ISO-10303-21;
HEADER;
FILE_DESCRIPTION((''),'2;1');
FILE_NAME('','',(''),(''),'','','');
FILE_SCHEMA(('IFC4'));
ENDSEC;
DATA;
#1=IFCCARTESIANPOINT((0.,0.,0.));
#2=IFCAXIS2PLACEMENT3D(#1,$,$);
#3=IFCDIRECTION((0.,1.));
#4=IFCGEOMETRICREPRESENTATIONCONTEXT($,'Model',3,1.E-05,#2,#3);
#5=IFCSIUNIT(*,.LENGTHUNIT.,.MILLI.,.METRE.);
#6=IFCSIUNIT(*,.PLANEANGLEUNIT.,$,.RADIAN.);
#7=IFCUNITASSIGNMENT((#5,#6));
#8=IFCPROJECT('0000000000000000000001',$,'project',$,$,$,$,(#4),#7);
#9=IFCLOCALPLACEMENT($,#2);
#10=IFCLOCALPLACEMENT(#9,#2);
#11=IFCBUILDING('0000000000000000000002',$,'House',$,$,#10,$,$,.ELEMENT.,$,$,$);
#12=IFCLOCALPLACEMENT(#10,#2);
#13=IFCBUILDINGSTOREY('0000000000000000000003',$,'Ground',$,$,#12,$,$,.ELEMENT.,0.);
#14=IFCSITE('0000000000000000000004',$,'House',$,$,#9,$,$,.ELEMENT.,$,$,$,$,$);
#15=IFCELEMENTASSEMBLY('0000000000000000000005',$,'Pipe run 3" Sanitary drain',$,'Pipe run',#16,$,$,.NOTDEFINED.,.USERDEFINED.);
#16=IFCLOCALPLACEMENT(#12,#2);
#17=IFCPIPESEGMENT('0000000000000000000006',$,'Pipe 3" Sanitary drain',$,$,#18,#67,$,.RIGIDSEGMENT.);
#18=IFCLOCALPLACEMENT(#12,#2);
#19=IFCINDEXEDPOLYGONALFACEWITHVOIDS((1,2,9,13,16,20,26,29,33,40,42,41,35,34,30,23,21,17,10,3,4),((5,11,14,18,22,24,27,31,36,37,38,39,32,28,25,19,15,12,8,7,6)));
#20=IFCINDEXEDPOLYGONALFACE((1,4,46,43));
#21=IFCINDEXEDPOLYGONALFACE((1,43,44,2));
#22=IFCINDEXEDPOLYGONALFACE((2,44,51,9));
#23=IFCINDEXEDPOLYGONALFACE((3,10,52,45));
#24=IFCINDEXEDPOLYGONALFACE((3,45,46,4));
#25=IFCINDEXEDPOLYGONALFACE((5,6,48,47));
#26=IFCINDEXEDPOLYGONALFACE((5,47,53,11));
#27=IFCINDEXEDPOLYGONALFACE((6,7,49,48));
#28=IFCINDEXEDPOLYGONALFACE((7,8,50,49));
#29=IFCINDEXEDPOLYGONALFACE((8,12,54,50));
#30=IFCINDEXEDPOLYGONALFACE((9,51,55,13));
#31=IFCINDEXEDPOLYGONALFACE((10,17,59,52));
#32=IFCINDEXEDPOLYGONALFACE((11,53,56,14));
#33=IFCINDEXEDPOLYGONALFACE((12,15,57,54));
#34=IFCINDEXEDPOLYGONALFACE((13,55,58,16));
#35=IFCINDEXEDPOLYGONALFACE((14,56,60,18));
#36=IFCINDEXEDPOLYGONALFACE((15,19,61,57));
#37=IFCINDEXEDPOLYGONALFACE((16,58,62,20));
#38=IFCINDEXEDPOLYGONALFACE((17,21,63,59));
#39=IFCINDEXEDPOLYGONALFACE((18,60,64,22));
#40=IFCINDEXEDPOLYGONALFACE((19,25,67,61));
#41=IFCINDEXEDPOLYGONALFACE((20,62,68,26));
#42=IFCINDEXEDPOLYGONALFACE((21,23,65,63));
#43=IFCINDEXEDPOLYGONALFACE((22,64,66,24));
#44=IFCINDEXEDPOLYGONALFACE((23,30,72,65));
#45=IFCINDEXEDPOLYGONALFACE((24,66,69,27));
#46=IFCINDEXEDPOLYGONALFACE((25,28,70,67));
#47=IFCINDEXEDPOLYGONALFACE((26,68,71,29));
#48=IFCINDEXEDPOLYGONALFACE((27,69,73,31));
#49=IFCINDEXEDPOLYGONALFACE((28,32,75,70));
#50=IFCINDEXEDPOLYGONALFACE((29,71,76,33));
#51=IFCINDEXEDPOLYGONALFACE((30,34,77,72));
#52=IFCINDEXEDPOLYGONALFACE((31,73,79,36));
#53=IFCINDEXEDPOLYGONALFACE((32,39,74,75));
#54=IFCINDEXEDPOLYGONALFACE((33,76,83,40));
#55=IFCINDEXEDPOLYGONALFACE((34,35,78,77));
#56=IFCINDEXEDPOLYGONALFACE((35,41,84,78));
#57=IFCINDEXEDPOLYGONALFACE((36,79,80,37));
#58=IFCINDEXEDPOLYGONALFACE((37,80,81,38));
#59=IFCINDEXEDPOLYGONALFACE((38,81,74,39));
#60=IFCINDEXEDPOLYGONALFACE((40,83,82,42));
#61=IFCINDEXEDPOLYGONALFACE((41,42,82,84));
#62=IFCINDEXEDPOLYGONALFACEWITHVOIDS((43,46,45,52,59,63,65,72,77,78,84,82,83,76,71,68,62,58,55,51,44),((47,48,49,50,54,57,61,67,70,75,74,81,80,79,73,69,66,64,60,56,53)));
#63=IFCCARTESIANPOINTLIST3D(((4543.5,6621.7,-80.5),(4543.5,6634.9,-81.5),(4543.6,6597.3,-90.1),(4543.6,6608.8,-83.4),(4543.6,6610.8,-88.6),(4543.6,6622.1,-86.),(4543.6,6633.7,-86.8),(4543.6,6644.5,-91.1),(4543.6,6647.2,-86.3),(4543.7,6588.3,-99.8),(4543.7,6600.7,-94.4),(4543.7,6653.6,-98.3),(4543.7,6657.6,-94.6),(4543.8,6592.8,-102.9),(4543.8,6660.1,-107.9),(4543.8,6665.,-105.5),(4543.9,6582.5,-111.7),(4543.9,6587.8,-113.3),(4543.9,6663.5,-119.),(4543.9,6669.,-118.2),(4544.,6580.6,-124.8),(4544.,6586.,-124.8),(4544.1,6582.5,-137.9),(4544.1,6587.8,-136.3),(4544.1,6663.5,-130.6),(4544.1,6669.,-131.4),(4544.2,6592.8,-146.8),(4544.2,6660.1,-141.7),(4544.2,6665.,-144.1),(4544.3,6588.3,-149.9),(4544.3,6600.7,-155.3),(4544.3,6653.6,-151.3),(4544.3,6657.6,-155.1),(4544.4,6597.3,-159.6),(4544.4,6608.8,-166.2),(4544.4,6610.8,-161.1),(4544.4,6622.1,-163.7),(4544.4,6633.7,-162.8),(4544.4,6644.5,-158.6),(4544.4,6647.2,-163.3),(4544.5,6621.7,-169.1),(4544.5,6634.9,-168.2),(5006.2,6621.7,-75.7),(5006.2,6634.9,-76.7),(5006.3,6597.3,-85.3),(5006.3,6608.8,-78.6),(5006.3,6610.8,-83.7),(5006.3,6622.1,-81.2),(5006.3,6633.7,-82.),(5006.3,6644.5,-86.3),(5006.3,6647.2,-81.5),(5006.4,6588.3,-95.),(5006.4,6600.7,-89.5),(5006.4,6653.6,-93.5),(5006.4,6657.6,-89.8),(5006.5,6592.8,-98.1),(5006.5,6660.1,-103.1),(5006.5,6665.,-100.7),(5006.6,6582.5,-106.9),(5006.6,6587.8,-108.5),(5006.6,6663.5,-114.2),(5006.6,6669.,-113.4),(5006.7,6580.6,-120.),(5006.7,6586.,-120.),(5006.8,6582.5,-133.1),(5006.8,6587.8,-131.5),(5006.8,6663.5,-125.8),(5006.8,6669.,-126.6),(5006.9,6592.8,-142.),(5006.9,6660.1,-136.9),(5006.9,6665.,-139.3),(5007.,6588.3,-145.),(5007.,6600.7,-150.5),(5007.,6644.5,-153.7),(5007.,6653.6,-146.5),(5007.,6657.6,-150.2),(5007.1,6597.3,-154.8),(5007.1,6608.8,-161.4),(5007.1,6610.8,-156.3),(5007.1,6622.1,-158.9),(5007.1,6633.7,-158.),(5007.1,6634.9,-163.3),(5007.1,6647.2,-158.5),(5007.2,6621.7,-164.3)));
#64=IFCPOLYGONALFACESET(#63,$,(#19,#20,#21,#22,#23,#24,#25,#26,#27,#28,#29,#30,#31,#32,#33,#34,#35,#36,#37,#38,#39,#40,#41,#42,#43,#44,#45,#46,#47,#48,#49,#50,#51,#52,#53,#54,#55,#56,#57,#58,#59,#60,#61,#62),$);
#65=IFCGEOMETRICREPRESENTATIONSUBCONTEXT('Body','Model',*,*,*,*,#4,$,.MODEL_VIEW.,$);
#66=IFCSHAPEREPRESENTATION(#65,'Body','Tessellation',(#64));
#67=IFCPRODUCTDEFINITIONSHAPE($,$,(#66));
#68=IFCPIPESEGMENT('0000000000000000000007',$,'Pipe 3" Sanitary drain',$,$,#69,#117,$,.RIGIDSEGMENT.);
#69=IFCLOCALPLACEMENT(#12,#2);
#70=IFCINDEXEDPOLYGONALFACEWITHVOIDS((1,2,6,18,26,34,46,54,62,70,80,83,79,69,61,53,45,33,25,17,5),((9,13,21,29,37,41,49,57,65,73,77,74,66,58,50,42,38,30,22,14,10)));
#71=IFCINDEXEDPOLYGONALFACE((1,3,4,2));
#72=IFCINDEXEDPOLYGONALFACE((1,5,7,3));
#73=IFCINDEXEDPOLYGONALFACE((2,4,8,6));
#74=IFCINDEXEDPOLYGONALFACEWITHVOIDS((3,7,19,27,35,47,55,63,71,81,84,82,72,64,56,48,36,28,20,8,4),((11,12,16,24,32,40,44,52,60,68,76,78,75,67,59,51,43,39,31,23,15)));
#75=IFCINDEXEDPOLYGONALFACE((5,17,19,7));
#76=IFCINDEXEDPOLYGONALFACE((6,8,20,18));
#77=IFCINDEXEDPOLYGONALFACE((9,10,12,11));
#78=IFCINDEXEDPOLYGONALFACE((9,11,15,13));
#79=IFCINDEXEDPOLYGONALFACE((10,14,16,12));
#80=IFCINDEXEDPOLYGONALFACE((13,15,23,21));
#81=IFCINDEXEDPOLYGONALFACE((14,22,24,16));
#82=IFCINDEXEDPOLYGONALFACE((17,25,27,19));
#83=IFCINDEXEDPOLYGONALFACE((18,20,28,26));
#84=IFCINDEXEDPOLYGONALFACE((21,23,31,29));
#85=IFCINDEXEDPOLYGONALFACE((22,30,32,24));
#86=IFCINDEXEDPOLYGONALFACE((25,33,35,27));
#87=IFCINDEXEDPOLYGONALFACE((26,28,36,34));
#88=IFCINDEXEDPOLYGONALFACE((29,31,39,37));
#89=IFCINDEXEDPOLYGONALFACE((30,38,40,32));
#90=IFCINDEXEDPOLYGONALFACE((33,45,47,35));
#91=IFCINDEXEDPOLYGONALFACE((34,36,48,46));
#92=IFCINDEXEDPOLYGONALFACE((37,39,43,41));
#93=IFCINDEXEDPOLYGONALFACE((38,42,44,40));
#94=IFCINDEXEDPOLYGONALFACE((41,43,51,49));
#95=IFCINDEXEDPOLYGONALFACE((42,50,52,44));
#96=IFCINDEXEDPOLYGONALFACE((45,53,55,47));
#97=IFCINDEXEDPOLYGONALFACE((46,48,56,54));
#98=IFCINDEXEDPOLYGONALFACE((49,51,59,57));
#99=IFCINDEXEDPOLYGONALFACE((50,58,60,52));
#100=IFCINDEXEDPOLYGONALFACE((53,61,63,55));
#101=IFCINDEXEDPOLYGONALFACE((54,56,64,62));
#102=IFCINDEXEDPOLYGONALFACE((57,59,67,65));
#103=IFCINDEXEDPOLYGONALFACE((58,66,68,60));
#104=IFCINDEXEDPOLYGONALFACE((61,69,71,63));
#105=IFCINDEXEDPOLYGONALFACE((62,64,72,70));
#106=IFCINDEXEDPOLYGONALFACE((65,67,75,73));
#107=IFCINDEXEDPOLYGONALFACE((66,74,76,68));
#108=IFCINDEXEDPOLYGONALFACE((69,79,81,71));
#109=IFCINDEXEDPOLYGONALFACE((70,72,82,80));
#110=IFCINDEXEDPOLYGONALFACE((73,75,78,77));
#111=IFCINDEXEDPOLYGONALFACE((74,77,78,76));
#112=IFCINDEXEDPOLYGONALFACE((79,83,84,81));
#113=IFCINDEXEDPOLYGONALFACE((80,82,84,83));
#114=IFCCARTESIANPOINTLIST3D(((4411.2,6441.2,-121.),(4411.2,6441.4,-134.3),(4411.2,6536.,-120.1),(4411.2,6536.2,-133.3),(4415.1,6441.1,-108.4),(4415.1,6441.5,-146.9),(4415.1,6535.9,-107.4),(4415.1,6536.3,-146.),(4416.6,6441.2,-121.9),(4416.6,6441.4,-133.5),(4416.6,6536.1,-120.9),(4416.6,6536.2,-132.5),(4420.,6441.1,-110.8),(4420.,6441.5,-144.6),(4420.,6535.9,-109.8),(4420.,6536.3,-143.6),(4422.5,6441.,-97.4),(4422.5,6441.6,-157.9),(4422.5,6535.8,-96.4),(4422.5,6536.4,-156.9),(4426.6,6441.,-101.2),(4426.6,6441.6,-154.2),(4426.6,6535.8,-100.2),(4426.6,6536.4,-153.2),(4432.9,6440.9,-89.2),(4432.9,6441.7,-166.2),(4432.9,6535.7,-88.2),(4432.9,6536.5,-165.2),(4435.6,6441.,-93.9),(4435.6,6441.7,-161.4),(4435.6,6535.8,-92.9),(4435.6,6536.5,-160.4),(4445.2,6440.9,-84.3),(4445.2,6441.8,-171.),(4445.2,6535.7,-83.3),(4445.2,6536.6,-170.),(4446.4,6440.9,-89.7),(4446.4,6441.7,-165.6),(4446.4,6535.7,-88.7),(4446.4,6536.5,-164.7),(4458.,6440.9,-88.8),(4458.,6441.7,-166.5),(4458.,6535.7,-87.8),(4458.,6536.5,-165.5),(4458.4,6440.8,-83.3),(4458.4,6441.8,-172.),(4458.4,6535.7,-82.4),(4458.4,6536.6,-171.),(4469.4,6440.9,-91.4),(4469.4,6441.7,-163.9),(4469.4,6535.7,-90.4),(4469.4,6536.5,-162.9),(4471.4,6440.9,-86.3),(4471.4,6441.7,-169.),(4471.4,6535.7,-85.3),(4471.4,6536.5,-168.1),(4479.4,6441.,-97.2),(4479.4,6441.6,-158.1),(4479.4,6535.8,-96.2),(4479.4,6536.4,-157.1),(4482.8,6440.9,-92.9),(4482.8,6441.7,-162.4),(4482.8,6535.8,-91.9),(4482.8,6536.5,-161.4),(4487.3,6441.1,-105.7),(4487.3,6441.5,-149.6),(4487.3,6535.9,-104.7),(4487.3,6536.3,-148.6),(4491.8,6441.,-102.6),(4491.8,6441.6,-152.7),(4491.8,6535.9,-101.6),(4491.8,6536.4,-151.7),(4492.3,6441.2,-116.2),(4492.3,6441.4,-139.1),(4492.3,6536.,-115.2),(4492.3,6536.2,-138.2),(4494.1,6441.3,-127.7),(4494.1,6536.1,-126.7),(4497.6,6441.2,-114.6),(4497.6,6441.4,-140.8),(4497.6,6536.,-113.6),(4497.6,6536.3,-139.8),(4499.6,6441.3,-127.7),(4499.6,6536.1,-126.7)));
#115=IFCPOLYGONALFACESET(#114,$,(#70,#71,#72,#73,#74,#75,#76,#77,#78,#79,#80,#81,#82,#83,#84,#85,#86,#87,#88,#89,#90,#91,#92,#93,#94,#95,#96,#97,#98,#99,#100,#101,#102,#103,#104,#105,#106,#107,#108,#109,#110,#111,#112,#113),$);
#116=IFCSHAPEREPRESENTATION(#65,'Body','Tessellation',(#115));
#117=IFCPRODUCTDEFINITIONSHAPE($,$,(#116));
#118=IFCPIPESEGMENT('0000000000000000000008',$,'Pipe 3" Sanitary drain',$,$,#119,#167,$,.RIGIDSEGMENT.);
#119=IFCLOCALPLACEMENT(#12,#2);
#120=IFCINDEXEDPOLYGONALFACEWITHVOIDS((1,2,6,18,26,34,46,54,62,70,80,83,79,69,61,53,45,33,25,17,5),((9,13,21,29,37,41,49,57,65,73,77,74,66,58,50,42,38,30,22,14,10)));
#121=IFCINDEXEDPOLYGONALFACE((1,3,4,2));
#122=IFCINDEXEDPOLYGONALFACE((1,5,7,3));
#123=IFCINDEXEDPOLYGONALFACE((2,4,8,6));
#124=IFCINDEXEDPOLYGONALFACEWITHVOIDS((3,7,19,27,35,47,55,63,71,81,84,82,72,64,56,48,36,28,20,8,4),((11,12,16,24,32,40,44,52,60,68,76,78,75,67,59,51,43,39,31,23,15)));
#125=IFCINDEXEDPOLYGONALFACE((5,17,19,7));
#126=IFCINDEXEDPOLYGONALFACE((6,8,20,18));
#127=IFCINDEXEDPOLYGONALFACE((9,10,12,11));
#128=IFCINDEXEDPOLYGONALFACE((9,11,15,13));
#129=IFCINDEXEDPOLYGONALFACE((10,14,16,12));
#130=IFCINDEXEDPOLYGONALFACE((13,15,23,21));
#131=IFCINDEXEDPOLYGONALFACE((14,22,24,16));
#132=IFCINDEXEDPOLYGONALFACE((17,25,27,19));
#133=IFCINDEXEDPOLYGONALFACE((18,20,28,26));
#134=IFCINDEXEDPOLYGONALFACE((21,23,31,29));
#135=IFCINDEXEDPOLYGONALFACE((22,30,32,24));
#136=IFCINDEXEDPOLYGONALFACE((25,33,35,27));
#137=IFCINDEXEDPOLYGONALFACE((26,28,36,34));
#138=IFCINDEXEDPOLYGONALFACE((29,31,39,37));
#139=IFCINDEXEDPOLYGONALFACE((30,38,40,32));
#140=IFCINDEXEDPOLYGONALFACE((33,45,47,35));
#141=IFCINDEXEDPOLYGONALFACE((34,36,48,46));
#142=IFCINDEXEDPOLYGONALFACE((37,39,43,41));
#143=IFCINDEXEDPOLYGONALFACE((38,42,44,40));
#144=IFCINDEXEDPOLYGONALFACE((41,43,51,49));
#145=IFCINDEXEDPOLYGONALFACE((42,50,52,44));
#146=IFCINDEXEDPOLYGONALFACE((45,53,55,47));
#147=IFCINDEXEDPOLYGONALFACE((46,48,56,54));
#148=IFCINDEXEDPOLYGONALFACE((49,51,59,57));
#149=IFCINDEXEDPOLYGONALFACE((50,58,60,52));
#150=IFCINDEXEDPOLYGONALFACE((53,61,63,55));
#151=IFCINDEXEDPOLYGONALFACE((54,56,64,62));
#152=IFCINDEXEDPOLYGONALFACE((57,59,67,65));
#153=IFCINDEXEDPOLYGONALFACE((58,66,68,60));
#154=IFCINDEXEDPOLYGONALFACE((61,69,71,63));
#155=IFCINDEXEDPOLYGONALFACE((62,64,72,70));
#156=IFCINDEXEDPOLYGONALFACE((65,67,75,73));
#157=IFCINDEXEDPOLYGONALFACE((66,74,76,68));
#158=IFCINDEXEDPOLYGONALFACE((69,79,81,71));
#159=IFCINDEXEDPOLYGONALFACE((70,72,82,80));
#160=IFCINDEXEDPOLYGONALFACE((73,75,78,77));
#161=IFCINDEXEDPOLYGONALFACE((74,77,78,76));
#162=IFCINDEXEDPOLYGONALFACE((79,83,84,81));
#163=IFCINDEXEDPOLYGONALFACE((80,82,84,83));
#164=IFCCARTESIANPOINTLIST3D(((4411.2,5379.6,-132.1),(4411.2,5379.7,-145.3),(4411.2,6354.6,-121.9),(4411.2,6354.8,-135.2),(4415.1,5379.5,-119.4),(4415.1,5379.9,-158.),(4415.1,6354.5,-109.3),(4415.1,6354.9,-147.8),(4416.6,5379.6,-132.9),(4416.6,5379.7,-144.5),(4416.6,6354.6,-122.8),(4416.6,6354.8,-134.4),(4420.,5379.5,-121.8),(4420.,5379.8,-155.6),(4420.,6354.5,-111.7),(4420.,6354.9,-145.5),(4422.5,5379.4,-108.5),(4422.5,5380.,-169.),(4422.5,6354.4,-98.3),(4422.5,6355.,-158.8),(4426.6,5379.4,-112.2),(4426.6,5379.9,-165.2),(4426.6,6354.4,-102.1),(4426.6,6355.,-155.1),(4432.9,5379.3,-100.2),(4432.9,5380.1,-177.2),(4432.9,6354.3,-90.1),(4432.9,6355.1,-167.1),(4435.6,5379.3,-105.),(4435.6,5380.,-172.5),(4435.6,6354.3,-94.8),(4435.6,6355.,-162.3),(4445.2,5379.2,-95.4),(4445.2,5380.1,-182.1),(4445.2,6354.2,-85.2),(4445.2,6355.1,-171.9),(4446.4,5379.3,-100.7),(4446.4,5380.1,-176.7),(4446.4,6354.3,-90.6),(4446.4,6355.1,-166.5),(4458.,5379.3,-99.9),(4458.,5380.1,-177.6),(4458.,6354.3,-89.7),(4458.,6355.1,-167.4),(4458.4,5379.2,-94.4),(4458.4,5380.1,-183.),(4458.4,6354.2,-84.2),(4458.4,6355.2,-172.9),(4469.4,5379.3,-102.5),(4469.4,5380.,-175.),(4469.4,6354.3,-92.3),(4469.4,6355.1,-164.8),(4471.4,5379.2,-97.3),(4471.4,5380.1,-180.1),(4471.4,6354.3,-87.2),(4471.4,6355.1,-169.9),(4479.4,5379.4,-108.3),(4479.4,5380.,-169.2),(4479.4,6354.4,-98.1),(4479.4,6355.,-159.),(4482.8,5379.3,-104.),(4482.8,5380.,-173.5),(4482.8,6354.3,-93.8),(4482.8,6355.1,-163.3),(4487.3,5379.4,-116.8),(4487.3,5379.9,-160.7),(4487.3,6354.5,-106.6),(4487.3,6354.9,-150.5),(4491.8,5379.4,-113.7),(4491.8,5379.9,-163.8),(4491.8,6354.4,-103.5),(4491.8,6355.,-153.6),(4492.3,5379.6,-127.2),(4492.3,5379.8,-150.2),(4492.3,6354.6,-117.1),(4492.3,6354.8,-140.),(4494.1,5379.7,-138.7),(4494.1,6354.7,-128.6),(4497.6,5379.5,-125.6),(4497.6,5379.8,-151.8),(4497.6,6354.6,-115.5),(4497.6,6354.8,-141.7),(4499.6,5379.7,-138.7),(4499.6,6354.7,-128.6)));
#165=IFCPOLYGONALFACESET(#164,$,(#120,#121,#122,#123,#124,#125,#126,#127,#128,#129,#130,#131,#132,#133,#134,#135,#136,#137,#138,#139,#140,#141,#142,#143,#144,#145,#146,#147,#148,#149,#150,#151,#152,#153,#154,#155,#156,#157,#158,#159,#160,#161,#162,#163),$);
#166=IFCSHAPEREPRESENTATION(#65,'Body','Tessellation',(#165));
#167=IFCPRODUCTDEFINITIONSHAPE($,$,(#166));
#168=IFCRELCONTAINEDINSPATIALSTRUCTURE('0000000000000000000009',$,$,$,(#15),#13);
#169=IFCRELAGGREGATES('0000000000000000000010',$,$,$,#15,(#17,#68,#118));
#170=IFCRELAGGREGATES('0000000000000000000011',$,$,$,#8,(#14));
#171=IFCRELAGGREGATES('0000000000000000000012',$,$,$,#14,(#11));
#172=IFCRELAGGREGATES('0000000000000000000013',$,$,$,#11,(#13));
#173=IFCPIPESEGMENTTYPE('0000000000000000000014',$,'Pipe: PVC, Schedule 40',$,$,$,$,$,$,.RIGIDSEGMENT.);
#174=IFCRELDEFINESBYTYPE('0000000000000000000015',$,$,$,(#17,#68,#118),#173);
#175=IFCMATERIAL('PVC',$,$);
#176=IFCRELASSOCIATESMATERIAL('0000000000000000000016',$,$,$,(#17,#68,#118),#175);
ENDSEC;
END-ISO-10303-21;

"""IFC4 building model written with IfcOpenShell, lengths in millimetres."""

from ifc_helpers import new_model, si_unit, direction, frame, origin, origin_with_axes, origin_2d, place, context, subcontext, project, spatial, hollow_circle, extrude, material, type_object, element, aggregate, save


model = new_model("IFC4")

# Units and contexts
model_context = context("Model", 3, precision=1e-05, world=origin(), true_north=direction((0.0, 1.0)))
body_context = subcontext(model_context, "Body", "Model", "MODEL_VIEW")
ifc_project = project(units=[si_unit("LENGTHUNIT", "METRE", prefix="MILLI"), si_unit("PLANEANGLEUNIT", "RADIAN")], contexts=[model_context])

# Site, building, storey
site_placement = place(None, origin())
site = spatial("IfcSite", under=ifc_project, at=site_placement, Name="House", CompositionType="ELEMENT")
building_placement = place(site_placement, origin())
building = spatial("IfcBuilding", under=site, at=building_placement, Name="House", CompositionType="ELEMENT")
storey_placement = place(building_placement, origin())
storey = spatial("IfcBuildingStorey", under=building, at=storey_placement, Name="Ground", CompositionType="ELEMENT", Elevation=0.0)

# Element assembly, pipe segments
ifc_material = material(Name="PVC")
pipe_segment_type = type_object("IfcPipeSegmentType", Name="Pipe: PVC, Schedule 40", PredefinedType="RIGIDSEGMENT")
assembly_1_placement = place(storey_placement, origin_with_axes())
assembly_1 = element("IfcElementAssembly", 1, at=assembly_1_placement, inside=storey, Name="Pipe run 3\" Sanitary drain", ObjectType="Pipe run", AssemblyPlace="NOTDEFINED", PredefinedType="USERDEFINED")
pipe_segment_1_placement = place(storey_placement, origin_with_axes())
pipe_segment_1 = element("IfcPipeSegment", 2, at=pipe_segment_1_placement, type_object=pipe_segment_type, material=ifc_material, Name="Pipe 3\" Sanitary drain", PredefinedType="RIGIDSEGMENT", context=body_context, shape_type="SweptSolid", body=[
    extrude(hollow_circle(Radius=44.5, WallThickness=5.5, at=origin_2d()), frame((5006.7, 6625.0, -120.0), z_axis=(-0.999946, 0.0, -0.010416), x_axis=(0.0, -1.0, 0.0)), (0.0, 0.0, 1.0), 462.7),
])
pipe_segment_2_placement = place(storey_placement, origin_with_axes())
pipe_segment_2 = element("IfcPipeSegment", 3, at=pipe_segment_2_placement, type_object=pipe_segment_type, material=ifc_material, Name="Pipe 3\" Sanitary drain", PredefinedType="RIGIDSEGMENT", context=body_context, shape_type="SweptSolid", body=[
    extrude(hollow_circle(Radius=44.5, WallThickness=5.5, at=origin_2d()), frame((4455.1, 6536.1, -126.7), z_axis=(0.0, -0.999946, -0.010416), x_axis=(1.0, 0.0, 0.0)), (0.0, 0.0, 1.0), 94.8),
])
pipe_segment_3_placement = place(storey_placement, origin_with_axes())
pipe_segment_3 = element("IfcPipeSegment", 4, at=pipe_segment_3_placement, type_object=pipe_segment_type, material=ifc_material, Name="Pipe 3\" Sanitary drain", PredefinedType="RIGIDSEGMENT", context=body_context, shape_type="SweptSolid", body=[
    extrude(hollow_circle(Radius=44.5, WallThickness=5.5, at=origin_2d()), frame((4455.1, 6354.7, -128.6), z_axis=(0.0, -0.999946, -0.010416), x_axis=(1.0, 0.0, 0.0)), (0.0, 0.0, 1.0), 975.1),
])

aggregate(assembly_1, [pipe_segment_1, pipe_segment_2, pipe_segment_3])

save(model, "model.ifc")
